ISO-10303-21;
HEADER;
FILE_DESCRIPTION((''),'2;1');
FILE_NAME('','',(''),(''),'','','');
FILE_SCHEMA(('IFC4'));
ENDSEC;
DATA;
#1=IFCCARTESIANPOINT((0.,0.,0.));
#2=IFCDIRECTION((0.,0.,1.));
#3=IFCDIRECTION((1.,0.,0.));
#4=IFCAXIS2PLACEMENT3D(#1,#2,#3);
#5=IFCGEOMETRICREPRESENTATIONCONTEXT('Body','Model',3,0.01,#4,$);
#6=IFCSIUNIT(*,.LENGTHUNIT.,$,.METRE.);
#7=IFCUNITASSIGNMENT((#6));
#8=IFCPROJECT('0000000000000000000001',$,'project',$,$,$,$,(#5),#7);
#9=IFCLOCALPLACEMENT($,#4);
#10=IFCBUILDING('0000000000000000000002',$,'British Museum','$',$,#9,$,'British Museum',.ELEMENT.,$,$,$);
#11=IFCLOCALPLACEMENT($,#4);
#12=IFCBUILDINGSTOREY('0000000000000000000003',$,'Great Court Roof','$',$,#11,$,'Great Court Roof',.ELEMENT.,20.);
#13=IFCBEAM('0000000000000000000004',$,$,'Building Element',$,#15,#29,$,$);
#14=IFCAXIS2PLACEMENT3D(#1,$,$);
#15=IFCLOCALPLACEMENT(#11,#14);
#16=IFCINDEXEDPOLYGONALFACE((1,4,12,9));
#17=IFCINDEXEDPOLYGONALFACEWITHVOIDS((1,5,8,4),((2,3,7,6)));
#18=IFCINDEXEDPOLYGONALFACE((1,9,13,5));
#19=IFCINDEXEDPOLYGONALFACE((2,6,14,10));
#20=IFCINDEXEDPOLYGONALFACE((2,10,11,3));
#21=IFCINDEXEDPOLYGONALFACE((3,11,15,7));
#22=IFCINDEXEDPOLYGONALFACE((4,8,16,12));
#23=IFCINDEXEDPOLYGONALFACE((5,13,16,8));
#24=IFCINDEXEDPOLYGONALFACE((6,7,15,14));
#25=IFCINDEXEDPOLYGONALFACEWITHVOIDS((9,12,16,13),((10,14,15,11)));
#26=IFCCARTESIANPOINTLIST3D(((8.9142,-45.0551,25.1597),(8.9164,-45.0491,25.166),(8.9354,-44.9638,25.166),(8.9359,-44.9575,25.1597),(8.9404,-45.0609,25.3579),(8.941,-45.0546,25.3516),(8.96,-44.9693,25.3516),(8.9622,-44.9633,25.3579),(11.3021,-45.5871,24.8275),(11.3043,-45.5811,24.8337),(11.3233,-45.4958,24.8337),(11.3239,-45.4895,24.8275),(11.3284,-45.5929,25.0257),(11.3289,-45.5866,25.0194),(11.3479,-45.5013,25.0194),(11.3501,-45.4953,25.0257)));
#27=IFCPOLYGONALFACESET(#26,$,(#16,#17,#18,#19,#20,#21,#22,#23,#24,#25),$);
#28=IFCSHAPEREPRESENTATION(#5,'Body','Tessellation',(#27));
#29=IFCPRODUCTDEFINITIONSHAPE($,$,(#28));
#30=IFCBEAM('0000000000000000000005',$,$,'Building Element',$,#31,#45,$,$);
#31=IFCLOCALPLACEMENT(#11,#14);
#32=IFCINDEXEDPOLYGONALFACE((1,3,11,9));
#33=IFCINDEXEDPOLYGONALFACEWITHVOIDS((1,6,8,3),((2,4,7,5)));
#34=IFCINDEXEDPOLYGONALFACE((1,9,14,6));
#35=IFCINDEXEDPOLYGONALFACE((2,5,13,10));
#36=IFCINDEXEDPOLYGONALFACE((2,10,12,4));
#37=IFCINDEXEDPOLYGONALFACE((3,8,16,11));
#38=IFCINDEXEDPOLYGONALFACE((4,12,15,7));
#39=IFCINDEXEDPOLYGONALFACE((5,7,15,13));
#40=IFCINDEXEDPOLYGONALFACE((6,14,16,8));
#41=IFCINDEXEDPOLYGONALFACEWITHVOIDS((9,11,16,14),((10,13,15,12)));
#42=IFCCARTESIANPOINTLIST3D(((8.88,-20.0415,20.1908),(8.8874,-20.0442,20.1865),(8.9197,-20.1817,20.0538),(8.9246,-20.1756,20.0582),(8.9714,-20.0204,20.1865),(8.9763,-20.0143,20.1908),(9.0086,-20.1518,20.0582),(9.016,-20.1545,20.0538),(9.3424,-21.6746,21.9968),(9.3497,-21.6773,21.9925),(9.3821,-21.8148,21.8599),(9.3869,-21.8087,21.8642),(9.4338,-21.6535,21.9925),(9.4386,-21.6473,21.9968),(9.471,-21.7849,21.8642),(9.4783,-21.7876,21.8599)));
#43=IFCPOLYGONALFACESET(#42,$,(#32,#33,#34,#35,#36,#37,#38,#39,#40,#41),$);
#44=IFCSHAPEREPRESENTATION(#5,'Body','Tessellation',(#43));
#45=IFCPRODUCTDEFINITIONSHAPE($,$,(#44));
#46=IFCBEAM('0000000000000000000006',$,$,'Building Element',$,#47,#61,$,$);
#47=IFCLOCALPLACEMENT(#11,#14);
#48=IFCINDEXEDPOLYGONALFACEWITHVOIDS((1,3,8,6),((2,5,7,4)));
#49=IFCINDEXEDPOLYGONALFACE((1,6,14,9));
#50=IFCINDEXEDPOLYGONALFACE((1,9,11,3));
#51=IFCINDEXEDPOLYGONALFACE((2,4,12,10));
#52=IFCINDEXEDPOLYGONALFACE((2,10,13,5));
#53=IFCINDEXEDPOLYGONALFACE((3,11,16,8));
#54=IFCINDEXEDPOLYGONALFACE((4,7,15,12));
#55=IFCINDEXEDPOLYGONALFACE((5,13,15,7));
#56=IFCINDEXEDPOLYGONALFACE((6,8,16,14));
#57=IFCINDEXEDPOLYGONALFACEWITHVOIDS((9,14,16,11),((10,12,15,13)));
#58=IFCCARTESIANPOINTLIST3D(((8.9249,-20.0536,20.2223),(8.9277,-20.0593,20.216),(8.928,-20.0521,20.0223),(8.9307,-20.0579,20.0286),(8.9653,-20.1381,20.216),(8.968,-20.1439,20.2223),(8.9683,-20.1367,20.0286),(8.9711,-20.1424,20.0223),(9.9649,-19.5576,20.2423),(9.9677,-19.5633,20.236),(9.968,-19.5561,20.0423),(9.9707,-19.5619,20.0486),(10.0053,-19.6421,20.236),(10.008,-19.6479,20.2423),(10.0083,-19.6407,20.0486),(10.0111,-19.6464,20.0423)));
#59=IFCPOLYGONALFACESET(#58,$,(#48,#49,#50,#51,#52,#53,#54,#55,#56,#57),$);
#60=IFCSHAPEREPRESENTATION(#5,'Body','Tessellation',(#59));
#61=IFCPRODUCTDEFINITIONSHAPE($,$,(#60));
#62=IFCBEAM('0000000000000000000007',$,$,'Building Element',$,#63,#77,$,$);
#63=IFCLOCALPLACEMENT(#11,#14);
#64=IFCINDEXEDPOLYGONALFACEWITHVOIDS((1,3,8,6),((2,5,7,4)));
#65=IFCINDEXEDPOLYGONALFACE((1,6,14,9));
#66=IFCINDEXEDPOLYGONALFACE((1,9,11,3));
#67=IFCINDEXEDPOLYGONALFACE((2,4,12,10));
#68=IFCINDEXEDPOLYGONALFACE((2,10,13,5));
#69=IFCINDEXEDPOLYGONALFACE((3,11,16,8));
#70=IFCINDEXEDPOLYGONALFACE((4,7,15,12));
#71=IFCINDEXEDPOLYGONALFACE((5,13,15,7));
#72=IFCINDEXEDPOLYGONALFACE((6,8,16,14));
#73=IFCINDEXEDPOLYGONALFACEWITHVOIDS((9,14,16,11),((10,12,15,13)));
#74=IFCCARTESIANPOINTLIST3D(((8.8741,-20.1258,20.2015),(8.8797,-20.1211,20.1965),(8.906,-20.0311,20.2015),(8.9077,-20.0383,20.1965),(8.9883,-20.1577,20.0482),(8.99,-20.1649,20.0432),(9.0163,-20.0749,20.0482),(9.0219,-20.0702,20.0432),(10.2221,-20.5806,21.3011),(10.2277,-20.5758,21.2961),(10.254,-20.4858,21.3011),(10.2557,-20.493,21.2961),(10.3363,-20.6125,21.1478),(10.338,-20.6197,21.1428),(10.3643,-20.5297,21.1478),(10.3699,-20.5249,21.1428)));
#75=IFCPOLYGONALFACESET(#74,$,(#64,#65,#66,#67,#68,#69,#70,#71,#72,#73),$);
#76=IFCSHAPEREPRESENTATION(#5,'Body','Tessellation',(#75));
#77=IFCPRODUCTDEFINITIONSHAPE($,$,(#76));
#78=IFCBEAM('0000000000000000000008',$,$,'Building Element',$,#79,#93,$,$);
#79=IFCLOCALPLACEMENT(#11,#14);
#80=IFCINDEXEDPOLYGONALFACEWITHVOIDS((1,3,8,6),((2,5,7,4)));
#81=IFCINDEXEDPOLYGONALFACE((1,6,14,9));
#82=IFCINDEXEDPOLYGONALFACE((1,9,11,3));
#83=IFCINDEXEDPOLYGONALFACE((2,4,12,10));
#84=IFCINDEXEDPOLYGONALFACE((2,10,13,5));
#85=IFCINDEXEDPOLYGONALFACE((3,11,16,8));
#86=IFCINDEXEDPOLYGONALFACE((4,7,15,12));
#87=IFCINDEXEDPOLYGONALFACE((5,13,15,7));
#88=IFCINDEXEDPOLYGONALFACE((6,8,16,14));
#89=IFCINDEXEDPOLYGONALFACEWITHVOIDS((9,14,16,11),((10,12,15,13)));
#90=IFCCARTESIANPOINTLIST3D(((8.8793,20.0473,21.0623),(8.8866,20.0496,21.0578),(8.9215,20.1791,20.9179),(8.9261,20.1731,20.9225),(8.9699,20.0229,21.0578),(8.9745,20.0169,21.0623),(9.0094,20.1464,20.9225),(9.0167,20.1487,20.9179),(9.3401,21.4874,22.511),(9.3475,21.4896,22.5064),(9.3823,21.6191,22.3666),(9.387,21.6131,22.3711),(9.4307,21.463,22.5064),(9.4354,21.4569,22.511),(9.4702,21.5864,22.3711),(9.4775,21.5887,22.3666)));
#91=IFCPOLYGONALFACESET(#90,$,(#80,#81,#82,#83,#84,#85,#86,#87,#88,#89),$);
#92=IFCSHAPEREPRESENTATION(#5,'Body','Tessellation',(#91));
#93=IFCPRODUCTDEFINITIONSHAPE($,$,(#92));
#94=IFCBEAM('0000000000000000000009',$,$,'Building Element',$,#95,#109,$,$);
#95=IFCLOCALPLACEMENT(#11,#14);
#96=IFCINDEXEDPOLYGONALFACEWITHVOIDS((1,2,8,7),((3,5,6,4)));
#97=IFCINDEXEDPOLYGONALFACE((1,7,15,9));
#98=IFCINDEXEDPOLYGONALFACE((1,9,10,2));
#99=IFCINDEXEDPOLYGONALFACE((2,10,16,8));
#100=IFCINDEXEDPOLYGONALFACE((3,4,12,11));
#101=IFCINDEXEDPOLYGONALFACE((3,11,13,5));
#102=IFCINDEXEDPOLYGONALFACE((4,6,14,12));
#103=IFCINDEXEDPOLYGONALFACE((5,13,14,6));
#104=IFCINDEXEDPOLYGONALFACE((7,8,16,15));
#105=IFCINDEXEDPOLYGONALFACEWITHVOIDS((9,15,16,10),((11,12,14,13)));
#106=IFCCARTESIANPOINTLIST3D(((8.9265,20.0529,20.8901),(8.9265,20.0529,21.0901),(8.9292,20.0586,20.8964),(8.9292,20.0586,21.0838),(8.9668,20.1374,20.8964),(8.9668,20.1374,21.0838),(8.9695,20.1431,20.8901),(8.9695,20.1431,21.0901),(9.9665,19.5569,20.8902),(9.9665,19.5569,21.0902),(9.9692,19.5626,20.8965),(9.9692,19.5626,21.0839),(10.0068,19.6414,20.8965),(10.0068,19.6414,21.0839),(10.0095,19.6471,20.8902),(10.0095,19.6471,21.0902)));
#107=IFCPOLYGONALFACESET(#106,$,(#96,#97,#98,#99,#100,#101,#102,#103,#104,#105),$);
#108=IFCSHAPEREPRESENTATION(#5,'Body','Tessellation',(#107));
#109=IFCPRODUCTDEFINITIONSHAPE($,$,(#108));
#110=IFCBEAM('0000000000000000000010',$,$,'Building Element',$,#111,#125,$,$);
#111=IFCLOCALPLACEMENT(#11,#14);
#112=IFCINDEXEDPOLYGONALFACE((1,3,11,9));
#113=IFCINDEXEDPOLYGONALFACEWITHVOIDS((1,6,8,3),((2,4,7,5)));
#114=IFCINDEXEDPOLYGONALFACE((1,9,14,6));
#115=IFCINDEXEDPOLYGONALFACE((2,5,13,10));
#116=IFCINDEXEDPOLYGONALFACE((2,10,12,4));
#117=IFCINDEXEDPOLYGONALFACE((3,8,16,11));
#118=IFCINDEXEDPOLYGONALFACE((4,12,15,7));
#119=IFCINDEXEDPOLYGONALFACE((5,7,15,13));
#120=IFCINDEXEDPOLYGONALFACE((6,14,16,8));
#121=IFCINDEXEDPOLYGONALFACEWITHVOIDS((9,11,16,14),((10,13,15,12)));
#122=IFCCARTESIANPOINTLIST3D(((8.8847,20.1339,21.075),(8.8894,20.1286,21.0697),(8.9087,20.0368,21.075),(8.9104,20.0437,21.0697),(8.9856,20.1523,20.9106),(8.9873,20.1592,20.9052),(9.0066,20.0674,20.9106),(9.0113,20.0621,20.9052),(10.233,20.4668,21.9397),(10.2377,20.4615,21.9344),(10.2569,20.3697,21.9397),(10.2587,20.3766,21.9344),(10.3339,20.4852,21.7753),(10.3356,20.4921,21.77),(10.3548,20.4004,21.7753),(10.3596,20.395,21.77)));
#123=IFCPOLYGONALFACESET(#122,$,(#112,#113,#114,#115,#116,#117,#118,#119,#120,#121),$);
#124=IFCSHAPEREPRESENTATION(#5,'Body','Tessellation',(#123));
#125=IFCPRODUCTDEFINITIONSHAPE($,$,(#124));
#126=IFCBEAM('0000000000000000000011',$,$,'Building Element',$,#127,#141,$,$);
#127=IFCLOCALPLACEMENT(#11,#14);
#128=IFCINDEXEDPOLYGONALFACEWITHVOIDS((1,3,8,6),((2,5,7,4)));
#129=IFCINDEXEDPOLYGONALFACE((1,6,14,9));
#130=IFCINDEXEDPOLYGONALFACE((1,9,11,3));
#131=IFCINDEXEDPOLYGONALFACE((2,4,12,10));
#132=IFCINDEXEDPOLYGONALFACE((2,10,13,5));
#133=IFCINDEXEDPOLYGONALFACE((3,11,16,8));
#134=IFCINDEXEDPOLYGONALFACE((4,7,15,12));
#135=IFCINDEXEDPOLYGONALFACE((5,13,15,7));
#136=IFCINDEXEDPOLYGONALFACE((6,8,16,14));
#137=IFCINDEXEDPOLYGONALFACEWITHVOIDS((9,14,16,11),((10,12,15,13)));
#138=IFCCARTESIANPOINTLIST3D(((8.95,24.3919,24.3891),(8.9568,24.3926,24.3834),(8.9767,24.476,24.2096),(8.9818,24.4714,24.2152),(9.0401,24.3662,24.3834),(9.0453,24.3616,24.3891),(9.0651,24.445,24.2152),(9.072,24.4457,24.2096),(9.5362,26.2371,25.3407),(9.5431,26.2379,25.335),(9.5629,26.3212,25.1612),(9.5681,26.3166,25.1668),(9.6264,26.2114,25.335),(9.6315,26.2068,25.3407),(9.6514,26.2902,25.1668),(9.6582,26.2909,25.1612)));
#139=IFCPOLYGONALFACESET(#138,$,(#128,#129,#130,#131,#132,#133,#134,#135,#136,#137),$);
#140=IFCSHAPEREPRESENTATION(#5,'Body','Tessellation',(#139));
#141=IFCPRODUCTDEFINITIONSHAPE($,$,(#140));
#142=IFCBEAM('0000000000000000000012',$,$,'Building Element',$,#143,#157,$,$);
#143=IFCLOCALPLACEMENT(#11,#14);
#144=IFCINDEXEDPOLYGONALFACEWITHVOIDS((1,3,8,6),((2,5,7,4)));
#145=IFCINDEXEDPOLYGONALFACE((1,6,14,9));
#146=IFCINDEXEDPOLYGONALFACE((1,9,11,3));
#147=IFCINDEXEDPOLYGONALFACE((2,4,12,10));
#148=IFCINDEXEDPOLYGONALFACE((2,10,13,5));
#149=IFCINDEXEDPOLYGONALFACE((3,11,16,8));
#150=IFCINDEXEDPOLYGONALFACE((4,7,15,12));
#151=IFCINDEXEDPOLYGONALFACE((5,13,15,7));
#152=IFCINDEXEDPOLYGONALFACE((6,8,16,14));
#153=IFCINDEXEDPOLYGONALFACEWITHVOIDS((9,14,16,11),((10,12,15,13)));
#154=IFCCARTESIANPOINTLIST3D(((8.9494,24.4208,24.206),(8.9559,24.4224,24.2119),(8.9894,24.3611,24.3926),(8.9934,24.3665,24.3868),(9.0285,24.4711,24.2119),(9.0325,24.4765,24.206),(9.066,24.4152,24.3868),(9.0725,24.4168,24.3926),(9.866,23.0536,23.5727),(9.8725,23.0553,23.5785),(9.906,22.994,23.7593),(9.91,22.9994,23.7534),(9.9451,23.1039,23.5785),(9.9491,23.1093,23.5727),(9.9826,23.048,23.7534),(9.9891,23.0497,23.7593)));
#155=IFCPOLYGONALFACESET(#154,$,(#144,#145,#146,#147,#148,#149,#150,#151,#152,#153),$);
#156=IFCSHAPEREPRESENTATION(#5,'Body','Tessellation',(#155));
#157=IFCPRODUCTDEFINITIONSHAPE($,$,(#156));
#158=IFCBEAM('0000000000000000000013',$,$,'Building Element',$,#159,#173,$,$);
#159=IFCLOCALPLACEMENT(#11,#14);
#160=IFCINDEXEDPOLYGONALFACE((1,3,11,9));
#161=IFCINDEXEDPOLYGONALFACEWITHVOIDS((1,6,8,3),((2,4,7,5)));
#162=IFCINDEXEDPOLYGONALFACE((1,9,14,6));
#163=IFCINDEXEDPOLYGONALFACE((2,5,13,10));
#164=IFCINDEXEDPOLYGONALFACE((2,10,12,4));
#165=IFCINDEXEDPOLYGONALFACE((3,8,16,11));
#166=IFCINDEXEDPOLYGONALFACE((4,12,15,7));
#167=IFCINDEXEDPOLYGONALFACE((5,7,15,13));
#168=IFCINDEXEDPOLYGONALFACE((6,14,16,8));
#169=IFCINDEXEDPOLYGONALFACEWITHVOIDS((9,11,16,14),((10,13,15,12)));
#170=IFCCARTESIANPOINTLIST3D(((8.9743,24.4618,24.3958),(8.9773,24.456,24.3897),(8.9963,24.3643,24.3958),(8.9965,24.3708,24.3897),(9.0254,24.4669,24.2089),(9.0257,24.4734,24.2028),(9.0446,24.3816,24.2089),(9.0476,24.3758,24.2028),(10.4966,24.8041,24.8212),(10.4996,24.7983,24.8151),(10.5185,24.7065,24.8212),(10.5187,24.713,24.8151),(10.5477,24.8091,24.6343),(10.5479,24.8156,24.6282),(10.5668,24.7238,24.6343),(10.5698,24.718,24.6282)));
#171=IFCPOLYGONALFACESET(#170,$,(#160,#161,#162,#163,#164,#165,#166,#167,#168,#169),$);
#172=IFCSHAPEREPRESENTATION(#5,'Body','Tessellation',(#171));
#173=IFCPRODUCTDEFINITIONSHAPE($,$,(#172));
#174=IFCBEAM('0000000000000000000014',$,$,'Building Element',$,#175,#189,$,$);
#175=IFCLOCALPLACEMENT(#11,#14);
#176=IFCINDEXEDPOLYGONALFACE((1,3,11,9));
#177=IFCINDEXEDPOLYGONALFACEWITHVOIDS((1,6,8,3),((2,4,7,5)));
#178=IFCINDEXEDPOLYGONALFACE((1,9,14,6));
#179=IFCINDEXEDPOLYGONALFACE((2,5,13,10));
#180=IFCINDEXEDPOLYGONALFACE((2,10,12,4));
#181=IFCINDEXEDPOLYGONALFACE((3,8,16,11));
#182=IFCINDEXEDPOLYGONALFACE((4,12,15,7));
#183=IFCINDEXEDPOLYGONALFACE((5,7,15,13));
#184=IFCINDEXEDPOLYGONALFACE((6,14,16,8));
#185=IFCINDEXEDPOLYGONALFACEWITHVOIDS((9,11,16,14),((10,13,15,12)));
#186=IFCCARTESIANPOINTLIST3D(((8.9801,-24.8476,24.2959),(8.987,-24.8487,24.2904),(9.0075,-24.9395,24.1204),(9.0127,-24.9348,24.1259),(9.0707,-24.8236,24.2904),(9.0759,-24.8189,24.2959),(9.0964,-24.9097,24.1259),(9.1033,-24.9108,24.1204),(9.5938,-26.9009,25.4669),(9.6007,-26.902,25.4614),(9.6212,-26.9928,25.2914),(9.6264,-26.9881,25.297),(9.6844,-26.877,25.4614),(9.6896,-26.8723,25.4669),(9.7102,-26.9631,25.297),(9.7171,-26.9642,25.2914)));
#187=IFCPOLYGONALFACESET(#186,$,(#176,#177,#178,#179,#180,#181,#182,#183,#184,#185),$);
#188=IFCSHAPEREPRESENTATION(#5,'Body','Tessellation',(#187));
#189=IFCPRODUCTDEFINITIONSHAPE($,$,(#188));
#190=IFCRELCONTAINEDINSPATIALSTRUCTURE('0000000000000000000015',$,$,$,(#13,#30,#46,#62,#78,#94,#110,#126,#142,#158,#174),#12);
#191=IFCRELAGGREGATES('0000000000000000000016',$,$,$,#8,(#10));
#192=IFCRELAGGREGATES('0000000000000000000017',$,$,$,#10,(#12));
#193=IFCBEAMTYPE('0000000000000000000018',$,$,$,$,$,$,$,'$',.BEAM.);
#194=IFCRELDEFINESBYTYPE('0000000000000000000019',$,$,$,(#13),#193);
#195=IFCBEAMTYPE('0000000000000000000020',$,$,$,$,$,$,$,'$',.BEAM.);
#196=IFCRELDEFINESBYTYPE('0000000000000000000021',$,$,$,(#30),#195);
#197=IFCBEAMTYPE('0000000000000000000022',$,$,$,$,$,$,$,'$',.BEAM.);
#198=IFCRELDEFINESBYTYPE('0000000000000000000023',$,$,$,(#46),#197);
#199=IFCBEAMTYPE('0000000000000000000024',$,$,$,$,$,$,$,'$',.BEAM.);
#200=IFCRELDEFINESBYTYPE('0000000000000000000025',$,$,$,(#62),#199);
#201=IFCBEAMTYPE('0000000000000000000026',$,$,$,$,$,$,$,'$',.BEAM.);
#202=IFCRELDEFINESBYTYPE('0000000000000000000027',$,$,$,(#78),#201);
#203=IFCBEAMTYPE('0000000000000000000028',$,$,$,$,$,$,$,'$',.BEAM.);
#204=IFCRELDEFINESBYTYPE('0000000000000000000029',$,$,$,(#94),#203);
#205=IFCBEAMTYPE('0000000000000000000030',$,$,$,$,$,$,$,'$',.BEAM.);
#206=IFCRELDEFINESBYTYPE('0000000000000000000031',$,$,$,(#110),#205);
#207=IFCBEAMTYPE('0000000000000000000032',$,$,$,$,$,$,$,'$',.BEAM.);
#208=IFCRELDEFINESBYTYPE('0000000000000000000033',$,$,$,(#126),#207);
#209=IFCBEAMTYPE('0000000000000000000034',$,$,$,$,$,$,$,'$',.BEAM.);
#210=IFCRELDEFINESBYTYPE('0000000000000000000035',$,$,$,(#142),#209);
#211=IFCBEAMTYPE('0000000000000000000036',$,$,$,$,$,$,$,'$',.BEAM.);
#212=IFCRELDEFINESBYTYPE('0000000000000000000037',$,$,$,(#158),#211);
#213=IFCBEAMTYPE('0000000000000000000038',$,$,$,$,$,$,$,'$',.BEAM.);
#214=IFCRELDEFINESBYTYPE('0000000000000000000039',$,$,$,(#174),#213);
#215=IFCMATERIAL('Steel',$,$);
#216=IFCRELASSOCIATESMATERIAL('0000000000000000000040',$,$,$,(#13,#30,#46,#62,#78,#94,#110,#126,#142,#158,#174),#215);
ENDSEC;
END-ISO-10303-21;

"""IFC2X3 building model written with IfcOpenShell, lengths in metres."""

from ifc_helpers import new_model, si_unit, frame, origin_with_axes, origin_2d, place, context, project, spatial, hollow_rectangle, extrude, material, type_object, element, save


model = new_model("IFC2X3")

# Units and contexts
model_context = context("Model", 3, precision=0.01, world=origin_with_axes(), identifier="Body")
ifc_project = project(units=[si_unit("LENGTHUNIT", "METRE")], contexts=[model_context])

# Building, storey
building_placement = place(None, origin_with_axes())
building = spatial("IfcBuilding", under=ifc_project, at=building_placement, Name="British Museum", Description="$", LongName="British Museum", CompositionType="ELEMENT")
storey_placement = place(None, origin_with_axes())
storey = spatial("IfcBuildingStorey", under=building, at=storey_placement, Name="Great Court Roof", Description="$", LongName="Great Court Roof", CompositionType="ELEMENT", Elevation=20.0)

# Beams
ifc_material = material(Name="Steel")
beam_type_1 = type_object("IfcBeamType", ElementType="$", PredefinedType="BEAM")
beam_1_placement = place(None, origin_with_axes())
element("IfcBeam", 1, at=beam_1_placement, inside=storey, type_object=beam_type_1, material=ifc_material, Description="Building Element", context=model_context, shape_type="SweptSolid", body=[
    extrude(hollow_rectangle(XDim=0.1, YDim=0.2, WallThickness=0.0063, InnerFilletRadius=0.0, OuterFilletRadius=0.0, at=origin_2d()), frame((8.9382, -45.0092, 25.2588), z_axis=(0.967193, -0.215481, -0.13456), x_axis=(0.217458, 0.97607, 0.0)), (0.0, 0.0, 1.0), 2.4689),
])
beam_type_2 = type_object("IfcBeamType", ElementType="$", PredefinedType="BEAM")
beam_2_placement = place(None, origin_with_axes())
element("IfcBeam", 2, at=beam_2_placement, inside=storey, type_object=beam_type_2, material=ifc_material, Description="Building Element", context=model_context, shape_type="SweptSolid", body=[
    extrude(hollow_rectangle(XDim=0.1, YDim=0.2, WallThickness=0.0063, InnerFilletRadius=0.0, OuterFilletRadius=0.0, at=origin_2d()), frame((8.948, -20.098, 20.1223), z_axis=(0.18654, -0.65893, 0.728708), x_axis=(0.962187, 0.27239, 0.0)), (0.0, 0.0, 1.0), 2.4784),
])
beam_type_3 = type_object("IfcBeamType", ElementType="$", PredefinedType="BEAM")
beam_3_placement = place(None, origin_with_axes())
element("IfcBeam", 3, at=beam_3_placement, inside=storey, type_object=beam_type_3, material=ifc_material, Description="Building Element", context=model_context, shape_type="SweptSolid", body=[
    extrude(hollow_rectangle(XDim=0.1, YDim=0.2, WallThickness=0.0063, InnerFilletRadius=0.0, OuterFilletRadius=0.0, at=origin_2d()), frame((8.948, -20.098, 20.1223), z_axis=(0.902468, 0.430408, 0.017344), x_axis=(-0.430473, 0.902603, 0.0)), (0.0, 0.0, 1.0), 1.1524),
])
beam_type_4 = type_object("IfcBeamType", ElementType="$", PredefinedType="BEAM")
beam_4_placement = place(None, origin_with_axes())
element("IfcBeam", 4, at=beam_4_placement, inside=storey, type_object=beam_type_4, material=ifc_material, Description="Building Element", context=model_context, shape_type="SweptSolid", body=[
    extrude(hollow_rectangle(XDim=0.1, YDim=0.2, WallThickness=0.0063, InnerFilletRadius=0.0, OuterFilletRadius=0.0, at=origin_2d()), frame((8.948, -20.098, 20.1223), z_axis=(0.749692, -0.252906, 0.611556), x_axis=(0.319648, 0.947536, 0.0)), (0.0, 0.0, 1.0), 1.7981),
])
beam_type_5 = type_object("IfcBeamType", ElementType="$", PredefinedType="BEAM")
beam_5_placement = place(None, origin_with_axes())
element("IfcBeam", 5, at=beam_5_placement, inside=storey, type_object=beam_type_5, material=ifc_material, Description="Building Element", context=model_context, shape_type="SweptSolid", body=[
    extrude(hollow_rectangle(XDim=0.1, YDim=0.2, WallThickness=0.0063, InnerFilletRadius=0.0, OuterFilletRadius=0.0, at=origin_2d()), frame((8.948, 20.098, 20.9901), z_axis=(0.220081, 0.68771, 0.691823), x_axis=(-0.952419, 0.304793, 0.0)), (0.0, 0.0, 1.0), 2.0939),
])
beam_type_6 = type_object("IfcBeamType", ElementType="$", PredefinedType="BEAM")
beam_6_placement = place(None, origin_with_axes())
element("IfcBeam", 6, at=beam_6_placement, inside=storey, type_object=beam_type_6, material=ifc_material, Description="Building Element", context=model_context, shape_type="SweptSolid", body=[
    extrude(hollow_rectangle(XDim=0.1, YDim=0.2, WallThickness=0.0063, InnerFilletRadius=0.0, OuterFilletRadius=0.0, at=origin_2d()), frame((8.948, 20.098, 20.9901), z_axis=(0.902603, -0.430473, 0.000016), x_axis=(0.430473, 0.902603, 0.0)), (0.0, 0.0, 1.0), 1.1522),
])
beam_type_7 = type_object("IfcBeamType", ElementType="$", PredefinedType="BEAM")
beam_7_placement = place(None, origin_with_axes())
element("IfcBeam", 7, at=beam_7_placement, inside=storey, type_object=beam_type_7, material=ifc_material, Description="Building Element", context=model_context, shape_type="SweptSolid", body=[
    extrude(hollow_rectangle(XDim=0.1, YDim=0.2, WallThickness=0.0063, InnerFilletRadius=0.0, OuterFilletRadius=0.0, at=origin_2d()), frame((8.948, 20.098, 20.9901), z_axis=(0.824139, 0.203498, 0.528568), x_axis=(-0.239722, 0.970842, 0.0)), (0.0, 0.0, 1.0), 1.636),
])
beam_type_8 = type_object("IfcBeamType", ElementType="$", PredefinedType="BEAM")
beam_8_placement = place(None, origin_with_axes())
element("IfcBeam", 8, at=beam_8_placement, inside=storey, type_object=beam_type_8, material=ifc_material, Description="Building Element", context=model_context, shape_type="SweptSolid", body=[
    extrude(hollow_rectangle(XDim=0.1, YDim=0.2, WallThickness=0.0063, InnerFilletRadius=0.0, OuterFilletRadius=0.0, at=origin_2d()), frame((9.011, 24.4188, 24.2993), z_axis=(0.271756, 0.855323, 0.441101), x_axis=(-0.953052, 0.302807, 0.0)), (0.0, 0.0, 1.0), 2.1573),
])
beam_type_9 = type_object("IfcBeamType", ElementType="$", PredefinedType="BEAM")
beam_9_placement = place(None, origin_with_axes())
element("IfcBeam", 9, at=beam_9_placement, inside=storey, type_object=beam_type_9, material=ifc_material, Description="Building Element", context=model_context, shape_type="SweptSolid", body=[
    extrude(hollow_rectangle(XDim=0.1, YDim=0.2, WallThickness=0.0063, InnerFilletRadius=0.0, OuterFilletRadius=0.0, at=origin_2d()), frame((9.011, 24.4188, 24.2993), z_axis=(0.51973, -0.775193, -0.359104), x_axis=(0.830596, 0.556875, 0.0)), (0.0, 0.0, 1.0), 1.7636),
])
beam_type_10 = type_object("IfcBeamType", ElementType="$", PredefinedType="BEAM")
beam_10_placement = place(None, origin_with_axes())
element("IfcBeam", 10, at=beam_10_placement, inside=storey, type_object=beam_type_10, material=ifc_material, Description="Building Element", context=model_context, shape_type="SweptSolid", body=[
    extrude(hollow_rectangle(XDim=0.1, YDim=0.2, WallThickness=0.0063, InnerFilletRadius=0.0, OuterFilletRadius=0.0, at=origin_2d()), frame((9.011, 24.4188, 24.2993), z_axis=(0.941289, 0.211623, 0.263043), x_axis=(-0.219348, 0.975647, 0.0)), (0.0, 0.0, 1.0), 1.6172),
])
beam_type_11 = type_object("IfcBeamType", ElementType="$", PredefinedType="BEAM")
beam_11_placement = place(None, origin_with_axes())
element("IfcBeam", 11, at=beam_11_placement, inside=storey, type_object=beam_type_11, material=ifc_material, Description="Building Element", context=model_context, shape_type="SweptSolid", body=[
    extrude(hollow_rectangle(XDim=0.1, YDim=0.2, WallThickness=0.0063, InnerFilletRadius=0.0, OuterFilletRadius=0.0, at=origin_2d()), frame((9.0417, -24.8792, 24.2082), z_axis=(0.251301, -0.84079, 0.4795), x_axis=(0.958119, 0.286369, 0.0)), (0.0, 0.0, 1.0), 2.4422),
])

save(model, "model.ifc")
